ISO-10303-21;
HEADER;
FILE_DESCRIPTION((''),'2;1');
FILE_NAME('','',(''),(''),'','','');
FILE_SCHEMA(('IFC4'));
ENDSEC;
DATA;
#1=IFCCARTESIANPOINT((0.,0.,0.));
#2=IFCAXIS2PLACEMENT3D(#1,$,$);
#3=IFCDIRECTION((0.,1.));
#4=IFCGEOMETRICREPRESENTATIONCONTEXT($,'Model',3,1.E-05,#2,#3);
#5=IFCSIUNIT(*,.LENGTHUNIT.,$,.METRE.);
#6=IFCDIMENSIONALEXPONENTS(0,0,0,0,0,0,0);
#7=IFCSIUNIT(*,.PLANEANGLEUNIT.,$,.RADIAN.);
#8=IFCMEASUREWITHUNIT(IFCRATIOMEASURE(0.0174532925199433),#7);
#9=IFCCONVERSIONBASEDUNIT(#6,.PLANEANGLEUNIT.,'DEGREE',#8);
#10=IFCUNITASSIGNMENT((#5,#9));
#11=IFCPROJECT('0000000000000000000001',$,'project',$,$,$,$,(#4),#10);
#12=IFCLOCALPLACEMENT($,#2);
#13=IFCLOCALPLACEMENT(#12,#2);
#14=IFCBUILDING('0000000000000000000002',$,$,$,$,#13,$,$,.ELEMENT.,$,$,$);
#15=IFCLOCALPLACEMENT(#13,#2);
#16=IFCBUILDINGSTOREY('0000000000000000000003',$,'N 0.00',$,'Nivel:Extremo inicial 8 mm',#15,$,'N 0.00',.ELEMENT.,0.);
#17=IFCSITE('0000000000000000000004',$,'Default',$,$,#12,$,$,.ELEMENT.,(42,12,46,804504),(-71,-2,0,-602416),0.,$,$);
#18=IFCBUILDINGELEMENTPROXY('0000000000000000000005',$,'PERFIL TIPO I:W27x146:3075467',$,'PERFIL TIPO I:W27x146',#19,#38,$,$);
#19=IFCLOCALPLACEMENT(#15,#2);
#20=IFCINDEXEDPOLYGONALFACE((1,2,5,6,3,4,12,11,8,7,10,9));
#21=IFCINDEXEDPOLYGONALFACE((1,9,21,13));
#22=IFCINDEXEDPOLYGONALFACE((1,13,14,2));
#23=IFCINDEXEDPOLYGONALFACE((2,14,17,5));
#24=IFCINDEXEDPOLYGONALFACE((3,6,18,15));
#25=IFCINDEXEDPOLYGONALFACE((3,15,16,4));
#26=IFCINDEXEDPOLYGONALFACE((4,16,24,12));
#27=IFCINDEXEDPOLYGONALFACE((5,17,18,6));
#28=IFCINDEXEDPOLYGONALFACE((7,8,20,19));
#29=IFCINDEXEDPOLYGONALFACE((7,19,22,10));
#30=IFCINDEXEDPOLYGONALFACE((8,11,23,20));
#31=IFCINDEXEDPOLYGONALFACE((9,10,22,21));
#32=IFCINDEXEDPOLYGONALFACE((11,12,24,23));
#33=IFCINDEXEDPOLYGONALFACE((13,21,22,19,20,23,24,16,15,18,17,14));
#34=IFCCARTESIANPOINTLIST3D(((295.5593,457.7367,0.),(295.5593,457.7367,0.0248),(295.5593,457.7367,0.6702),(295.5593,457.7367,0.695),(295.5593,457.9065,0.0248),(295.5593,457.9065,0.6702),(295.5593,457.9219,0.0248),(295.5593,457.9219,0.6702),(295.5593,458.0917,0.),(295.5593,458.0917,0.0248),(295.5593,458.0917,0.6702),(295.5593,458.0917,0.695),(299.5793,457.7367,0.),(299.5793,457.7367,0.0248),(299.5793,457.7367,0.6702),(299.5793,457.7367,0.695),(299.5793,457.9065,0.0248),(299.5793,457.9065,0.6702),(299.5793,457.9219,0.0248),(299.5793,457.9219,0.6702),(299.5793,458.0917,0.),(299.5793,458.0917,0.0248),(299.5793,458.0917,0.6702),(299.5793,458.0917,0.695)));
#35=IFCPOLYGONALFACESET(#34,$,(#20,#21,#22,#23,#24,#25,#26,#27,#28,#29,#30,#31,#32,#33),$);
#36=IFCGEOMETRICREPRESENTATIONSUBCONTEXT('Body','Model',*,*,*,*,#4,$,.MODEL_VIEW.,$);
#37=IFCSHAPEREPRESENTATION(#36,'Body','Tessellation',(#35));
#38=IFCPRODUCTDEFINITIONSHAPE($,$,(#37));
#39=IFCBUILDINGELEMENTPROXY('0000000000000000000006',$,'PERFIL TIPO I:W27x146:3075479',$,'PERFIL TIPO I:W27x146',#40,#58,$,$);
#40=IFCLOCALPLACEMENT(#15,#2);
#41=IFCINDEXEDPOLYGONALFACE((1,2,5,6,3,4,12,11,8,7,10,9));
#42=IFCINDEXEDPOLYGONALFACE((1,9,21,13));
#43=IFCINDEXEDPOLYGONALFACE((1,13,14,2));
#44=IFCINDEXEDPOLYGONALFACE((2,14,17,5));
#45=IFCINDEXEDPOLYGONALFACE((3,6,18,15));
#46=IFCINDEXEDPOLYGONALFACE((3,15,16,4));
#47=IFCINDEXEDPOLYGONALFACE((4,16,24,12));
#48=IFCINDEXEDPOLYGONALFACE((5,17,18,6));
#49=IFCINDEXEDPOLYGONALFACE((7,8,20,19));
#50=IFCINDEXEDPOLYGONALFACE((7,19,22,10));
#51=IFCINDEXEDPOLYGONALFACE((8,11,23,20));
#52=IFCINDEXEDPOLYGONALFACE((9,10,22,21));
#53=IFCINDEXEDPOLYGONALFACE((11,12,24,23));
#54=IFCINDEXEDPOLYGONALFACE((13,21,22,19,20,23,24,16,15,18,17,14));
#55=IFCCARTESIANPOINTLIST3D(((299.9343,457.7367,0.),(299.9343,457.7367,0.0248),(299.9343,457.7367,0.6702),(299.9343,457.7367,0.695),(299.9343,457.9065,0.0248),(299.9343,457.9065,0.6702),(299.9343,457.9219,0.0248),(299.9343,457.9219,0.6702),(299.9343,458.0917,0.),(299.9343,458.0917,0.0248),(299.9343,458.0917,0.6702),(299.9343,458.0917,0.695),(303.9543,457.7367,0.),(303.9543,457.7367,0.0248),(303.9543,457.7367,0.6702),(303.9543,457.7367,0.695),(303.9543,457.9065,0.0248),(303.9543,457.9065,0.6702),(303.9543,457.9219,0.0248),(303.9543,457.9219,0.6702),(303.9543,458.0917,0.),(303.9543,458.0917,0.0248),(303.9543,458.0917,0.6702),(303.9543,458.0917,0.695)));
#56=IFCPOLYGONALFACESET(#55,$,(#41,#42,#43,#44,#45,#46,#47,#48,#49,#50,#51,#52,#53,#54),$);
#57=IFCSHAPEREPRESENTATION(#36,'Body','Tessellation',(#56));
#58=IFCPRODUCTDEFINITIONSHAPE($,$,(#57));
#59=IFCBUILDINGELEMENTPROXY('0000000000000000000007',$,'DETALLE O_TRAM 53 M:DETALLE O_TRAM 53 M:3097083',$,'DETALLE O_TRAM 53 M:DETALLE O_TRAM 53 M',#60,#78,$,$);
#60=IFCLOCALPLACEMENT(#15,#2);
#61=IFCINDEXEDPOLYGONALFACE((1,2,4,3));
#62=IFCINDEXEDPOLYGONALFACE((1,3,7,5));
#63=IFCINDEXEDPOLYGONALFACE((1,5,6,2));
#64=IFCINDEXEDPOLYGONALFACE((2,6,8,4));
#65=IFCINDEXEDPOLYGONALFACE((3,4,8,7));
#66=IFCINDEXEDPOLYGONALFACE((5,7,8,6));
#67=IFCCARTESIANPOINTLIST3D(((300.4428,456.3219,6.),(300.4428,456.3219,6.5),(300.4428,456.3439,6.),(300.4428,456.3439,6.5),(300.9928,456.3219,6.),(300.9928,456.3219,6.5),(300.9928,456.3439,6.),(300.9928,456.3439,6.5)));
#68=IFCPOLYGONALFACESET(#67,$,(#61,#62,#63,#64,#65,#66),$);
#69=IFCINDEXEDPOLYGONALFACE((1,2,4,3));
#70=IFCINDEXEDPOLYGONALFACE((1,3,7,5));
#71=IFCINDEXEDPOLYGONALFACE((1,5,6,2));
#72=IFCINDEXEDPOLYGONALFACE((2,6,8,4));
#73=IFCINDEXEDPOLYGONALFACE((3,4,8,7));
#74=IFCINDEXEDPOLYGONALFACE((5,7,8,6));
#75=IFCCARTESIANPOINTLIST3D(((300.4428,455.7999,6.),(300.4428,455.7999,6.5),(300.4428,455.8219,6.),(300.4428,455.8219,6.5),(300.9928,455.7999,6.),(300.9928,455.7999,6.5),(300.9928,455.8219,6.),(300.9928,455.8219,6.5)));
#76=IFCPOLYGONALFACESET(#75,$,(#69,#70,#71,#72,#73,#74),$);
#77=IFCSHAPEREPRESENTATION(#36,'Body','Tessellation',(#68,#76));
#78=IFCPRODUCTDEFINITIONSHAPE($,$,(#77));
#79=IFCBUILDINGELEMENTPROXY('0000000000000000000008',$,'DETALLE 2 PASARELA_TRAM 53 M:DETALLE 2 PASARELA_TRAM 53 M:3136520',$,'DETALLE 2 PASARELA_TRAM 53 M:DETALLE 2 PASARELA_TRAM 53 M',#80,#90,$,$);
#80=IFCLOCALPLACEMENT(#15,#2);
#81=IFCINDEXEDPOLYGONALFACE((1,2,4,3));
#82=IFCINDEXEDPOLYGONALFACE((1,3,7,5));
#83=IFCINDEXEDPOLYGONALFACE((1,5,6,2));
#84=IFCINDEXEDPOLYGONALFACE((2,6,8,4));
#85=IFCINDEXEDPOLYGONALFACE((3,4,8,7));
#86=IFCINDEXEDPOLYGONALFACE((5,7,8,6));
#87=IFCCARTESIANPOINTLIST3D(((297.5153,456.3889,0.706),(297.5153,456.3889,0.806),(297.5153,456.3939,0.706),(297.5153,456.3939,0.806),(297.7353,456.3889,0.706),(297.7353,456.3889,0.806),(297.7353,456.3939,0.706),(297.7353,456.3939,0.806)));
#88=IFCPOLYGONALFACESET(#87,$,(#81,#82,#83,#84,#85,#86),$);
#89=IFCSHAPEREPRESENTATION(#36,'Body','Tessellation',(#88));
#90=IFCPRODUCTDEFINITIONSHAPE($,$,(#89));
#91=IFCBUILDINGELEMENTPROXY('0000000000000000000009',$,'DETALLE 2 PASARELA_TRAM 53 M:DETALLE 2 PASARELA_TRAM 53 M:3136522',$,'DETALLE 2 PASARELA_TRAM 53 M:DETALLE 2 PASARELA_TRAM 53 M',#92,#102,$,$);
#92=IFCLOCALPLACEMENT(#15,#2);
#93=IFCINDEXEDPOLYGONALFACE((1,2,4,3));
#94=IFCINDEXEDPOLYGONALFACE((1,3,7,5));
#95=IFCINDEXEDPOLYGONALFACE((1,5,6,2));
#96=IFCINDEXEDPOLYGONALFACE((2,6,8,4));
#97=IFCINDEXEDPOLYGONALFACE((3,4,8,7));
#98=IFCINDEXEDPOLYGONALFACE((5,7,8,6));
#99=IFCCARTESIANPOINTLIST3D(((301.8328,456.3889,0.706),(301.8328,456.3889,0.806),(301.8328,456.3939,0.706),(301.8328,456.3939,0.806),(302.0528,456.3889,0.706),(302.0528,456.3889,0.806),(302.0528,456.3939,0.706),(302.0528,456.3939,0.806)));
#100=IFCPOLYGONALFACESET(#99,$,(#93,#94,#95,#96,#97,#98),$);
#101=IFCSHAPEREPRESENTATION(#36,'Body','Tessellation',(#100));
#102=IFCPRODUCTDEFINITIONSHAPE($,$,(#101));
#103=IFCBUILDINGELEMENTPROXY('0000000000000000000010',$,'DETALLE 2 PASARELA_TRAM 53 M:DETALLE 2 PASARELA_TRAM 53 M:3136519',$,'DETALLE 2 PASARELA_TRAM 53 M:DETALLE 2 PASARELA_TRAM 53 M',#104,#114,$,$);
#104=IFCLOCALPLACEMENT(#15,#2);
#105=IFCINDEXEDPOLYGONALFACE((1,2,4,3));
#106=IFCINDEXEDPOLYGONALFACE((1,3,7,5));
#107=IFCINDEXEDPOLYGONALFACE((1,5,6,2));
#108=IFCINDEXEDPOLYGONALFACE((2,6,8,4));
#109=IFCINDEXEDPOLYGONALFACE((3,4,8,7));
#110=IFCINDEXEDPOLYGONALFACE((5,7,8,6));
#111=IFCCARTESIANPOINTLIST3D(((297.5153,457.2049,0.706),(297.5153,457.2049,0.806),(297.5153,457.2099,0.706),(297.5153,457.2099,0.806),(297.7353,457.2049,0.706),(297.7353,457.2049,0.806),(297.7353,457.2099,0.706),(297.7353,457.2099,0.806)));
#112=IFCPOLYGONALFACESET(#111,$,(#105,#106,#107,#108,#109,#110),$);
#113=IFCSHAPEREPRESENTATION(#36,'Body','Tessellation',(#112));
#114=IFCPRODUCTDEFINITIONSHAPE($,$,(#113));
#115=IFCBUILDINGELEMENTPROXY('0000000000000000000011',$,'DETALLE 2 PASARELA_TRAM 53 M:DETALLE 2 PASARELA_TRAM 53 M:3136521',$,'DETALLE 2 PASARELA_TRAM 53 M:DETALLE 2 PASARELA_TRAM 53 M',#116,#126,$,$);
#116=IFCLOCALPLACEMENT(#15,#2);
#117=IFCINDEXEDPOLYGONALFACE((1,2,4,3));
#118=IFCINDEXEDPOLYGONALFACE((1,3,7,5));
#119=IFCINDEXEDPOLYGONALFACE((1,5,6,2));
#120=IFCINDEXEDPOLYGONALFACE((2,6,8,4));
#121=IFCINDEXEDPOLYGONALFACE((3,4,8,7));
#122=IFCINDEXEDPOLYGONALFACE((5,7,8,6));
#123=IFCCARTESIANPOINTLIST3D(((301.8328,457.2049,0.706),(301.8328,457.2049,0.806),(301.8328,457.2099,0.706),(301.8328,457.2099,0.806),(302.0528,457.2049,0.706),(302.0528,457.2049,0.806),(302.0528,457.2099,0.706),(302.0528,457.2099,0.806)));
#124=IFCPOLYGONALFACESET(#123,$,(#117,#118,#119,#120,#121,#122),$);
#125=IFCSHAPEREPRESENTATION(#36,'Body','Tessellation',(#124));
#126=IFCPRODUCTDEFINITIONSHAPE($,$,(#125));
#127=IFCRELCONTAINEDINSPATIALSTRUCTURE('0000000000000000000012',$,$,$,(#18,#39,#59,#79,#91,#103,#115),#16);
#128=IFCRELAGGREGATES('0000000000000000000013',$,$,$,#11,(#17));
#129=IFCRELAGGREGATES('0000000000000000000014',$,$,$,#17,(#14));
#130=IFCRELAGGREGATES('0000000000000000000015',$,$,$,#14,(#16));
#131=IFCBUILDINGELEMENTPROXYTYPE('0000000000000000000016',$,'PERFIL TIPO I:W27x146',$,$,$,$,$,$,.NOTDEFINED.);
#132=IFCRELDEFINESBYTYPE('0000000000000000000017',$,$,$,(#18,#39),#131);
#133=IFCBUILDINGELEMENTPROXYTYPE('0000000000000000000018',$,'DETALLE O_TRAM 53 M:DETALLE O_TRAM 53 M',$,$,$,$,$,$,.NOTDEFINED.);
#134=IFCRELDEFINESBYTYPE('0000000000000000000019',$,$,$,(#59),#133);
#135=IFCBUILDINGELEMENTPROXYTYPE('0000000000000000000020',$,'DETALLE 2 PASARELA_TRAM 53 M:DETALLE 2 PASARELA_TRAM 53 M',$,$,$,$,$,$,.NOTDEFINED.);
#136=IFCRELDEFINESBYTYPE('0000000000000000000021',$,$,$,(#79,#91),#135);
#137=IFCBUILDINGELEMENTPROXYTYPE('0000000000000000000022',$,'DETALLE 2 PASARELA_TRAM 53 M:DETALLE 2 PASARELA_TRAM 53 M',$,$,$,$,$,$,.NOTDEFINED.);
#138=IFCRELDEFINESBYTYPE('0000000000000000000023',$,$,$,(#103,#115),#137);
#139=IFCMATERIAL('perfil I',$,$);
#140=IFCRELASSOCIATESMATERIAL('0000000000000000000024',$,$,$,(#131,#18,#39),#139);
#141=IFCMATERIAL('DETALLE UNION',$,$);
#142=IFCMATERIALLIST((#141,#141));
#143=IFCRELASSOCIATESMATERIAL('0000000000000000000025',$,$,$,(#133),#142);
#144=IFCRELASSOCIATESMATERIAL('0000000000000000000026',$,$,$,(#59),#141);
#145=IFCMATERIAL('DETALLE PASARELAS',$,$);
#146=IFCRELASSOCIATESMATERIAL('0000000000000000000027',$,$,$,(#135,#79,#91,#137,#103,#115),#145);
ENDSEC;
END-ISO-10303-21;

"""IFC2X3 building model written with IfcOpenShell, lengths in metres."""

from ifc_helpers import new_model, entity, si_unit, converted_unit, direction, frame, frame_2d, origin, place, context, subcontext, project, spatial, polyline, rectangle, outline, extrude, source, transform, mapped, material, material_list, type_object, type_shapes, element, save


model = new_model("IFC2X3")

# Units and contexts
model_context = context("Model", 3, precision=1e-05, world=origin(), true_north=direction((0.0, 1.0)))
body_context = subcontext(model_context, "Body", "Model", "MODEL_VIEW")
ifc_project = project(units=[si_unit("LENGTHUNIT", "METRE"), converted_unit("PLANEANGLEUNIT", "DEGREE", entity("IfcRatioMeasure", 0.0174532925199433), si_unit("PLANEANGLEUNIT", "RADIAN"), dimensions=[0, 0, 0, 0, 0, 0, 0])], contexts=[model_context])

# Site, building, storey
site_placement = place(None, origin())
site = spatial("IfcSite", under=ifc_project, at=site_placement, Name="Default", CompositionType="ELEMENT", RefLatitude=(42, 12, 46, 804504), RefLongitude=(-71, -2, 0, -602416), RefElevation=0.0)
building_placement = place(site_placement, origin())
building = spatial("IfcBuilding", under=site, at=building_placement, CompositionType="ELEMENT")
storey_placement = place(building_placement, origin())
storey = spatial("IfcBuildingStorey", under=building, at=storey_placement, Name="N 0.00", ObjectType="Nivel:Extremo inicial 8 mm", LongName="N 0.00", CompositionType="ELEMENT", Elevation=0.0)

# Building element proxies
ifc_material_1 = material(Name="perfil I")
building_element_proxy_type_1 = type_object("IfcBuildingElementProxyType", Name="PERFIL TIPO I:W27x146", PredefinedType="NOTDEFINED", material=ifc_material_1)
shared_shape_1 = source(origin(), body_context, "Body", "SweptSolid", [
    extrude(outline(polyline([(0.3227, -0.1775), (0.3475, -0.1775), (0.3475, 0.1775), (0.3227, 0.1775), (0.3227, 0.0077), (-0.3227, 0.0077), (-0.3227, 0.1775), (-0.3475, 0.1775), (-0.3475, -0.1775), (-0.3227, -0.1775), (-0.3227, -0.0077), (0.3227, -0.0077), (0.3227, -0.1775)])), frame((0.0, 0.0, 0.3475), z_axis=(1.0, 0.0, 0.0), x_axis=(0.0, 0.0, 1.0)), (0.0, 0.0, 1.0), 4.02),
])
type_shapes(building_element_proxy_type_1, [shared_shape_1])
for number, where, name in (
    (1, (295.5593, 457.9142, 0.0), "PERFIL TIPO I:W27x146:3075467"),
    (2, (299.9343, 457.9142, 0.0), "PERFIL TIPO I:W27x146:3075479"),
):
    element("IfcBuildingElementProxy", number, at=place(storey_placement, frame(where)), inside=storey, type_object=building_element_proxy_type_1, material=ifc_material_1, Name=name, ObjectType="PERFIL TIPO I:W27x146", context=body_context, shape_type="MappedRepresentation", body=[
        mapped(shared_shape_1, transform((0.0, 0.0, 0.0), scale=1.0)),
    ])
ifc_material_2 = material(Name="DETALLE UNION")
ifc_material_list_1 = material_list([ifc_material_2, ifc_material_2])
building_element_proxy_type_2 = type_object("IfcBuildingElementProxyType", Name="DETALLE O_TRAM 53 M:DETALLE O_TRAM 53 M", PredefinedType="NOTDEFINED", material=ifc_material_list_1)
shared_shape_2 = source(origin(), body_context, "Body", "SweptSolid", [
    extrude(rectangle(XDim=0.55, YDim=0.022, at=frame_2d((0.0, 0.0), x_axis=(1.0, 0.0))), frame((0.275, 0.011, 0.0), z_axis=(0.0, 0.0, 1.0), x_axis=(-1.0, 0.0, 0.0)), (0.0, 0.0, 1.0), 0.5),
    extrude(rectangle(XDim=0.55, YDim=0.022, at=frame_2d((0.0, 0.0), x_axis=(1.0, 0.0))), frame((0.275, -0.511, 0.0), z_axis=(0.0, 0.0, 1.0), x_axis=(-1.0, 0.0, 0.0)), (0.0, 0.0, 1.0), 0.5),
])
type_shapes(building_element_proxy_type_2, [shared_shape_2])
proxy_1_placement = place(storey_placement, frame((300.4428, 456.3219, 6.0)))
element("IfcBuildingElementProxy", 3, at=proxy_1_placement, inside=storey, type_object=building_element_proxy_type_2, material=ifc_material_2, Name="DETALLE O_TRAM 53 M:DETALLE O_TRAM 53 M:3097083", ObjectType="DETALLE O_TRAM 53 M:DETALLE O_TRAM 53 M", context=body_context, shape_type="MappedRepresentation", body=[
    mapped(shared_shape_2, transform((0.0, 0.0, 0.0), scale=1.0)),
])
ifc_material_3 = material(Name="DETALLE PASARELAS")
building_element_proxy_type_3 = type_object("IfcBuildingElementProxyType", Name="DETALLE 2 PASARELA_TRAM 53 M:DETALLE 2 PASARELA_TRAM 53 M", PredefinedType="NOTDEFINED", material=ifc_material_3)
shared_shape_3 = source(origin(), body_context, "Body", "SweptSolid", [
    extrude(rectangle(XDim=0.22, YDim=0.005, at=frame_2d((0.0, 0.0), x_axis=(1.0, 0.0))), frame((0.11, 0.0475, 0.0), z_axis=(0.0, 0.0, 1.0), x_axis=(-1.0, 0.0, 0.0)), (0.0, 0.0, 1.0), 0.1),
])
type_shapes(building_element_proxy_type_3, [shared_shape_3])
for number, where, name in (
    (4, (297.5153, 456.3439, 0.706), "DETALLE 2 PASARELA_TRAM 53 M:DETALLE 2 PASARELA_TRAM 53 M:3136520"),
    (5, (301.8328, 456.3439, 0.706), "DETALLE 2 PASARELA_TRAM 53 M:DETALLE 2 PASARELA_TRAM 53 M:3136522"),
):
    element("IfcBuildingElementProxy", number, at=place(storey_placement, frame(where)), inside=storey, type_object=building_element_proxy_type_3, material=ifc_material_3, Name=name, ObjectType="DETALLE 2 PASARELA_TRAM 53 M:DETALLE 2 PASARELA_TRAM 53 M", context=body_context, shape_type="MappedRepresentation", body=[
        mapped(shared_shape_3, transform((0.0, 0.0, 0.0), scale=1.0)),
    ])
building_element_proxy_type_4 = type_object("IfcBuildingElementProxyType", Name="DETALLE 2 PASARELA_TRAM 53 M:DETALLE 2 PASARELA_TRAM 53 M", PredefinedType="NOTDEFINED", material=ifc_material_3)
shared_shape_4 = source(origin(), body_context, "Body", "SweptSolid", [
    extrude(rectangle(XDim=0.005, YDim=0.22, at=frame_2d((0.0, 0.0), x_axis=(1.0, 0.0))), frame((0.11, -0.0475, 0.0), z_axis=(0.0, 0.0, 1.0), x_axis=(0.0, 1.0, 0.0)), (0.0, 0.0, 1.0), 0.1),
])
type_shapes(building_element_proxy_type_4, [shared_shape_4])
for number, where, name in (
    (6, (297.5153, 457.2549, 0.706), "DETALLE 2 PASARELA_TRAM 53 M:DETALLE 2 PASARELA_TRAM 53 M:3136519"),
    (7, (301.8328, 457.2549, 0.706), "DETALLE 2 PASARELA_TRAM 53 M:DETALLE 2 PASARELA_TRAM 53 M:3136521"),
):
    element("IfcBuildingElementProxy", number, at=place(storey_placement, frame(where)), inside=storey, type_object=building_element_proxy_type_4, material=ifc_material_3, Name=name, ObjectType="DETALLE 2 PASARELA_TRAM 53 M:DETALLE 2 PASARELA_TRAM 53 M", context=body_context, shape_type="MappedRepresentation", body=[
        mapped(shared_shape_4, transform((0.0, 0.0, 0.0), scale=1.0)),
    ])

save(model, "model.ifc")
